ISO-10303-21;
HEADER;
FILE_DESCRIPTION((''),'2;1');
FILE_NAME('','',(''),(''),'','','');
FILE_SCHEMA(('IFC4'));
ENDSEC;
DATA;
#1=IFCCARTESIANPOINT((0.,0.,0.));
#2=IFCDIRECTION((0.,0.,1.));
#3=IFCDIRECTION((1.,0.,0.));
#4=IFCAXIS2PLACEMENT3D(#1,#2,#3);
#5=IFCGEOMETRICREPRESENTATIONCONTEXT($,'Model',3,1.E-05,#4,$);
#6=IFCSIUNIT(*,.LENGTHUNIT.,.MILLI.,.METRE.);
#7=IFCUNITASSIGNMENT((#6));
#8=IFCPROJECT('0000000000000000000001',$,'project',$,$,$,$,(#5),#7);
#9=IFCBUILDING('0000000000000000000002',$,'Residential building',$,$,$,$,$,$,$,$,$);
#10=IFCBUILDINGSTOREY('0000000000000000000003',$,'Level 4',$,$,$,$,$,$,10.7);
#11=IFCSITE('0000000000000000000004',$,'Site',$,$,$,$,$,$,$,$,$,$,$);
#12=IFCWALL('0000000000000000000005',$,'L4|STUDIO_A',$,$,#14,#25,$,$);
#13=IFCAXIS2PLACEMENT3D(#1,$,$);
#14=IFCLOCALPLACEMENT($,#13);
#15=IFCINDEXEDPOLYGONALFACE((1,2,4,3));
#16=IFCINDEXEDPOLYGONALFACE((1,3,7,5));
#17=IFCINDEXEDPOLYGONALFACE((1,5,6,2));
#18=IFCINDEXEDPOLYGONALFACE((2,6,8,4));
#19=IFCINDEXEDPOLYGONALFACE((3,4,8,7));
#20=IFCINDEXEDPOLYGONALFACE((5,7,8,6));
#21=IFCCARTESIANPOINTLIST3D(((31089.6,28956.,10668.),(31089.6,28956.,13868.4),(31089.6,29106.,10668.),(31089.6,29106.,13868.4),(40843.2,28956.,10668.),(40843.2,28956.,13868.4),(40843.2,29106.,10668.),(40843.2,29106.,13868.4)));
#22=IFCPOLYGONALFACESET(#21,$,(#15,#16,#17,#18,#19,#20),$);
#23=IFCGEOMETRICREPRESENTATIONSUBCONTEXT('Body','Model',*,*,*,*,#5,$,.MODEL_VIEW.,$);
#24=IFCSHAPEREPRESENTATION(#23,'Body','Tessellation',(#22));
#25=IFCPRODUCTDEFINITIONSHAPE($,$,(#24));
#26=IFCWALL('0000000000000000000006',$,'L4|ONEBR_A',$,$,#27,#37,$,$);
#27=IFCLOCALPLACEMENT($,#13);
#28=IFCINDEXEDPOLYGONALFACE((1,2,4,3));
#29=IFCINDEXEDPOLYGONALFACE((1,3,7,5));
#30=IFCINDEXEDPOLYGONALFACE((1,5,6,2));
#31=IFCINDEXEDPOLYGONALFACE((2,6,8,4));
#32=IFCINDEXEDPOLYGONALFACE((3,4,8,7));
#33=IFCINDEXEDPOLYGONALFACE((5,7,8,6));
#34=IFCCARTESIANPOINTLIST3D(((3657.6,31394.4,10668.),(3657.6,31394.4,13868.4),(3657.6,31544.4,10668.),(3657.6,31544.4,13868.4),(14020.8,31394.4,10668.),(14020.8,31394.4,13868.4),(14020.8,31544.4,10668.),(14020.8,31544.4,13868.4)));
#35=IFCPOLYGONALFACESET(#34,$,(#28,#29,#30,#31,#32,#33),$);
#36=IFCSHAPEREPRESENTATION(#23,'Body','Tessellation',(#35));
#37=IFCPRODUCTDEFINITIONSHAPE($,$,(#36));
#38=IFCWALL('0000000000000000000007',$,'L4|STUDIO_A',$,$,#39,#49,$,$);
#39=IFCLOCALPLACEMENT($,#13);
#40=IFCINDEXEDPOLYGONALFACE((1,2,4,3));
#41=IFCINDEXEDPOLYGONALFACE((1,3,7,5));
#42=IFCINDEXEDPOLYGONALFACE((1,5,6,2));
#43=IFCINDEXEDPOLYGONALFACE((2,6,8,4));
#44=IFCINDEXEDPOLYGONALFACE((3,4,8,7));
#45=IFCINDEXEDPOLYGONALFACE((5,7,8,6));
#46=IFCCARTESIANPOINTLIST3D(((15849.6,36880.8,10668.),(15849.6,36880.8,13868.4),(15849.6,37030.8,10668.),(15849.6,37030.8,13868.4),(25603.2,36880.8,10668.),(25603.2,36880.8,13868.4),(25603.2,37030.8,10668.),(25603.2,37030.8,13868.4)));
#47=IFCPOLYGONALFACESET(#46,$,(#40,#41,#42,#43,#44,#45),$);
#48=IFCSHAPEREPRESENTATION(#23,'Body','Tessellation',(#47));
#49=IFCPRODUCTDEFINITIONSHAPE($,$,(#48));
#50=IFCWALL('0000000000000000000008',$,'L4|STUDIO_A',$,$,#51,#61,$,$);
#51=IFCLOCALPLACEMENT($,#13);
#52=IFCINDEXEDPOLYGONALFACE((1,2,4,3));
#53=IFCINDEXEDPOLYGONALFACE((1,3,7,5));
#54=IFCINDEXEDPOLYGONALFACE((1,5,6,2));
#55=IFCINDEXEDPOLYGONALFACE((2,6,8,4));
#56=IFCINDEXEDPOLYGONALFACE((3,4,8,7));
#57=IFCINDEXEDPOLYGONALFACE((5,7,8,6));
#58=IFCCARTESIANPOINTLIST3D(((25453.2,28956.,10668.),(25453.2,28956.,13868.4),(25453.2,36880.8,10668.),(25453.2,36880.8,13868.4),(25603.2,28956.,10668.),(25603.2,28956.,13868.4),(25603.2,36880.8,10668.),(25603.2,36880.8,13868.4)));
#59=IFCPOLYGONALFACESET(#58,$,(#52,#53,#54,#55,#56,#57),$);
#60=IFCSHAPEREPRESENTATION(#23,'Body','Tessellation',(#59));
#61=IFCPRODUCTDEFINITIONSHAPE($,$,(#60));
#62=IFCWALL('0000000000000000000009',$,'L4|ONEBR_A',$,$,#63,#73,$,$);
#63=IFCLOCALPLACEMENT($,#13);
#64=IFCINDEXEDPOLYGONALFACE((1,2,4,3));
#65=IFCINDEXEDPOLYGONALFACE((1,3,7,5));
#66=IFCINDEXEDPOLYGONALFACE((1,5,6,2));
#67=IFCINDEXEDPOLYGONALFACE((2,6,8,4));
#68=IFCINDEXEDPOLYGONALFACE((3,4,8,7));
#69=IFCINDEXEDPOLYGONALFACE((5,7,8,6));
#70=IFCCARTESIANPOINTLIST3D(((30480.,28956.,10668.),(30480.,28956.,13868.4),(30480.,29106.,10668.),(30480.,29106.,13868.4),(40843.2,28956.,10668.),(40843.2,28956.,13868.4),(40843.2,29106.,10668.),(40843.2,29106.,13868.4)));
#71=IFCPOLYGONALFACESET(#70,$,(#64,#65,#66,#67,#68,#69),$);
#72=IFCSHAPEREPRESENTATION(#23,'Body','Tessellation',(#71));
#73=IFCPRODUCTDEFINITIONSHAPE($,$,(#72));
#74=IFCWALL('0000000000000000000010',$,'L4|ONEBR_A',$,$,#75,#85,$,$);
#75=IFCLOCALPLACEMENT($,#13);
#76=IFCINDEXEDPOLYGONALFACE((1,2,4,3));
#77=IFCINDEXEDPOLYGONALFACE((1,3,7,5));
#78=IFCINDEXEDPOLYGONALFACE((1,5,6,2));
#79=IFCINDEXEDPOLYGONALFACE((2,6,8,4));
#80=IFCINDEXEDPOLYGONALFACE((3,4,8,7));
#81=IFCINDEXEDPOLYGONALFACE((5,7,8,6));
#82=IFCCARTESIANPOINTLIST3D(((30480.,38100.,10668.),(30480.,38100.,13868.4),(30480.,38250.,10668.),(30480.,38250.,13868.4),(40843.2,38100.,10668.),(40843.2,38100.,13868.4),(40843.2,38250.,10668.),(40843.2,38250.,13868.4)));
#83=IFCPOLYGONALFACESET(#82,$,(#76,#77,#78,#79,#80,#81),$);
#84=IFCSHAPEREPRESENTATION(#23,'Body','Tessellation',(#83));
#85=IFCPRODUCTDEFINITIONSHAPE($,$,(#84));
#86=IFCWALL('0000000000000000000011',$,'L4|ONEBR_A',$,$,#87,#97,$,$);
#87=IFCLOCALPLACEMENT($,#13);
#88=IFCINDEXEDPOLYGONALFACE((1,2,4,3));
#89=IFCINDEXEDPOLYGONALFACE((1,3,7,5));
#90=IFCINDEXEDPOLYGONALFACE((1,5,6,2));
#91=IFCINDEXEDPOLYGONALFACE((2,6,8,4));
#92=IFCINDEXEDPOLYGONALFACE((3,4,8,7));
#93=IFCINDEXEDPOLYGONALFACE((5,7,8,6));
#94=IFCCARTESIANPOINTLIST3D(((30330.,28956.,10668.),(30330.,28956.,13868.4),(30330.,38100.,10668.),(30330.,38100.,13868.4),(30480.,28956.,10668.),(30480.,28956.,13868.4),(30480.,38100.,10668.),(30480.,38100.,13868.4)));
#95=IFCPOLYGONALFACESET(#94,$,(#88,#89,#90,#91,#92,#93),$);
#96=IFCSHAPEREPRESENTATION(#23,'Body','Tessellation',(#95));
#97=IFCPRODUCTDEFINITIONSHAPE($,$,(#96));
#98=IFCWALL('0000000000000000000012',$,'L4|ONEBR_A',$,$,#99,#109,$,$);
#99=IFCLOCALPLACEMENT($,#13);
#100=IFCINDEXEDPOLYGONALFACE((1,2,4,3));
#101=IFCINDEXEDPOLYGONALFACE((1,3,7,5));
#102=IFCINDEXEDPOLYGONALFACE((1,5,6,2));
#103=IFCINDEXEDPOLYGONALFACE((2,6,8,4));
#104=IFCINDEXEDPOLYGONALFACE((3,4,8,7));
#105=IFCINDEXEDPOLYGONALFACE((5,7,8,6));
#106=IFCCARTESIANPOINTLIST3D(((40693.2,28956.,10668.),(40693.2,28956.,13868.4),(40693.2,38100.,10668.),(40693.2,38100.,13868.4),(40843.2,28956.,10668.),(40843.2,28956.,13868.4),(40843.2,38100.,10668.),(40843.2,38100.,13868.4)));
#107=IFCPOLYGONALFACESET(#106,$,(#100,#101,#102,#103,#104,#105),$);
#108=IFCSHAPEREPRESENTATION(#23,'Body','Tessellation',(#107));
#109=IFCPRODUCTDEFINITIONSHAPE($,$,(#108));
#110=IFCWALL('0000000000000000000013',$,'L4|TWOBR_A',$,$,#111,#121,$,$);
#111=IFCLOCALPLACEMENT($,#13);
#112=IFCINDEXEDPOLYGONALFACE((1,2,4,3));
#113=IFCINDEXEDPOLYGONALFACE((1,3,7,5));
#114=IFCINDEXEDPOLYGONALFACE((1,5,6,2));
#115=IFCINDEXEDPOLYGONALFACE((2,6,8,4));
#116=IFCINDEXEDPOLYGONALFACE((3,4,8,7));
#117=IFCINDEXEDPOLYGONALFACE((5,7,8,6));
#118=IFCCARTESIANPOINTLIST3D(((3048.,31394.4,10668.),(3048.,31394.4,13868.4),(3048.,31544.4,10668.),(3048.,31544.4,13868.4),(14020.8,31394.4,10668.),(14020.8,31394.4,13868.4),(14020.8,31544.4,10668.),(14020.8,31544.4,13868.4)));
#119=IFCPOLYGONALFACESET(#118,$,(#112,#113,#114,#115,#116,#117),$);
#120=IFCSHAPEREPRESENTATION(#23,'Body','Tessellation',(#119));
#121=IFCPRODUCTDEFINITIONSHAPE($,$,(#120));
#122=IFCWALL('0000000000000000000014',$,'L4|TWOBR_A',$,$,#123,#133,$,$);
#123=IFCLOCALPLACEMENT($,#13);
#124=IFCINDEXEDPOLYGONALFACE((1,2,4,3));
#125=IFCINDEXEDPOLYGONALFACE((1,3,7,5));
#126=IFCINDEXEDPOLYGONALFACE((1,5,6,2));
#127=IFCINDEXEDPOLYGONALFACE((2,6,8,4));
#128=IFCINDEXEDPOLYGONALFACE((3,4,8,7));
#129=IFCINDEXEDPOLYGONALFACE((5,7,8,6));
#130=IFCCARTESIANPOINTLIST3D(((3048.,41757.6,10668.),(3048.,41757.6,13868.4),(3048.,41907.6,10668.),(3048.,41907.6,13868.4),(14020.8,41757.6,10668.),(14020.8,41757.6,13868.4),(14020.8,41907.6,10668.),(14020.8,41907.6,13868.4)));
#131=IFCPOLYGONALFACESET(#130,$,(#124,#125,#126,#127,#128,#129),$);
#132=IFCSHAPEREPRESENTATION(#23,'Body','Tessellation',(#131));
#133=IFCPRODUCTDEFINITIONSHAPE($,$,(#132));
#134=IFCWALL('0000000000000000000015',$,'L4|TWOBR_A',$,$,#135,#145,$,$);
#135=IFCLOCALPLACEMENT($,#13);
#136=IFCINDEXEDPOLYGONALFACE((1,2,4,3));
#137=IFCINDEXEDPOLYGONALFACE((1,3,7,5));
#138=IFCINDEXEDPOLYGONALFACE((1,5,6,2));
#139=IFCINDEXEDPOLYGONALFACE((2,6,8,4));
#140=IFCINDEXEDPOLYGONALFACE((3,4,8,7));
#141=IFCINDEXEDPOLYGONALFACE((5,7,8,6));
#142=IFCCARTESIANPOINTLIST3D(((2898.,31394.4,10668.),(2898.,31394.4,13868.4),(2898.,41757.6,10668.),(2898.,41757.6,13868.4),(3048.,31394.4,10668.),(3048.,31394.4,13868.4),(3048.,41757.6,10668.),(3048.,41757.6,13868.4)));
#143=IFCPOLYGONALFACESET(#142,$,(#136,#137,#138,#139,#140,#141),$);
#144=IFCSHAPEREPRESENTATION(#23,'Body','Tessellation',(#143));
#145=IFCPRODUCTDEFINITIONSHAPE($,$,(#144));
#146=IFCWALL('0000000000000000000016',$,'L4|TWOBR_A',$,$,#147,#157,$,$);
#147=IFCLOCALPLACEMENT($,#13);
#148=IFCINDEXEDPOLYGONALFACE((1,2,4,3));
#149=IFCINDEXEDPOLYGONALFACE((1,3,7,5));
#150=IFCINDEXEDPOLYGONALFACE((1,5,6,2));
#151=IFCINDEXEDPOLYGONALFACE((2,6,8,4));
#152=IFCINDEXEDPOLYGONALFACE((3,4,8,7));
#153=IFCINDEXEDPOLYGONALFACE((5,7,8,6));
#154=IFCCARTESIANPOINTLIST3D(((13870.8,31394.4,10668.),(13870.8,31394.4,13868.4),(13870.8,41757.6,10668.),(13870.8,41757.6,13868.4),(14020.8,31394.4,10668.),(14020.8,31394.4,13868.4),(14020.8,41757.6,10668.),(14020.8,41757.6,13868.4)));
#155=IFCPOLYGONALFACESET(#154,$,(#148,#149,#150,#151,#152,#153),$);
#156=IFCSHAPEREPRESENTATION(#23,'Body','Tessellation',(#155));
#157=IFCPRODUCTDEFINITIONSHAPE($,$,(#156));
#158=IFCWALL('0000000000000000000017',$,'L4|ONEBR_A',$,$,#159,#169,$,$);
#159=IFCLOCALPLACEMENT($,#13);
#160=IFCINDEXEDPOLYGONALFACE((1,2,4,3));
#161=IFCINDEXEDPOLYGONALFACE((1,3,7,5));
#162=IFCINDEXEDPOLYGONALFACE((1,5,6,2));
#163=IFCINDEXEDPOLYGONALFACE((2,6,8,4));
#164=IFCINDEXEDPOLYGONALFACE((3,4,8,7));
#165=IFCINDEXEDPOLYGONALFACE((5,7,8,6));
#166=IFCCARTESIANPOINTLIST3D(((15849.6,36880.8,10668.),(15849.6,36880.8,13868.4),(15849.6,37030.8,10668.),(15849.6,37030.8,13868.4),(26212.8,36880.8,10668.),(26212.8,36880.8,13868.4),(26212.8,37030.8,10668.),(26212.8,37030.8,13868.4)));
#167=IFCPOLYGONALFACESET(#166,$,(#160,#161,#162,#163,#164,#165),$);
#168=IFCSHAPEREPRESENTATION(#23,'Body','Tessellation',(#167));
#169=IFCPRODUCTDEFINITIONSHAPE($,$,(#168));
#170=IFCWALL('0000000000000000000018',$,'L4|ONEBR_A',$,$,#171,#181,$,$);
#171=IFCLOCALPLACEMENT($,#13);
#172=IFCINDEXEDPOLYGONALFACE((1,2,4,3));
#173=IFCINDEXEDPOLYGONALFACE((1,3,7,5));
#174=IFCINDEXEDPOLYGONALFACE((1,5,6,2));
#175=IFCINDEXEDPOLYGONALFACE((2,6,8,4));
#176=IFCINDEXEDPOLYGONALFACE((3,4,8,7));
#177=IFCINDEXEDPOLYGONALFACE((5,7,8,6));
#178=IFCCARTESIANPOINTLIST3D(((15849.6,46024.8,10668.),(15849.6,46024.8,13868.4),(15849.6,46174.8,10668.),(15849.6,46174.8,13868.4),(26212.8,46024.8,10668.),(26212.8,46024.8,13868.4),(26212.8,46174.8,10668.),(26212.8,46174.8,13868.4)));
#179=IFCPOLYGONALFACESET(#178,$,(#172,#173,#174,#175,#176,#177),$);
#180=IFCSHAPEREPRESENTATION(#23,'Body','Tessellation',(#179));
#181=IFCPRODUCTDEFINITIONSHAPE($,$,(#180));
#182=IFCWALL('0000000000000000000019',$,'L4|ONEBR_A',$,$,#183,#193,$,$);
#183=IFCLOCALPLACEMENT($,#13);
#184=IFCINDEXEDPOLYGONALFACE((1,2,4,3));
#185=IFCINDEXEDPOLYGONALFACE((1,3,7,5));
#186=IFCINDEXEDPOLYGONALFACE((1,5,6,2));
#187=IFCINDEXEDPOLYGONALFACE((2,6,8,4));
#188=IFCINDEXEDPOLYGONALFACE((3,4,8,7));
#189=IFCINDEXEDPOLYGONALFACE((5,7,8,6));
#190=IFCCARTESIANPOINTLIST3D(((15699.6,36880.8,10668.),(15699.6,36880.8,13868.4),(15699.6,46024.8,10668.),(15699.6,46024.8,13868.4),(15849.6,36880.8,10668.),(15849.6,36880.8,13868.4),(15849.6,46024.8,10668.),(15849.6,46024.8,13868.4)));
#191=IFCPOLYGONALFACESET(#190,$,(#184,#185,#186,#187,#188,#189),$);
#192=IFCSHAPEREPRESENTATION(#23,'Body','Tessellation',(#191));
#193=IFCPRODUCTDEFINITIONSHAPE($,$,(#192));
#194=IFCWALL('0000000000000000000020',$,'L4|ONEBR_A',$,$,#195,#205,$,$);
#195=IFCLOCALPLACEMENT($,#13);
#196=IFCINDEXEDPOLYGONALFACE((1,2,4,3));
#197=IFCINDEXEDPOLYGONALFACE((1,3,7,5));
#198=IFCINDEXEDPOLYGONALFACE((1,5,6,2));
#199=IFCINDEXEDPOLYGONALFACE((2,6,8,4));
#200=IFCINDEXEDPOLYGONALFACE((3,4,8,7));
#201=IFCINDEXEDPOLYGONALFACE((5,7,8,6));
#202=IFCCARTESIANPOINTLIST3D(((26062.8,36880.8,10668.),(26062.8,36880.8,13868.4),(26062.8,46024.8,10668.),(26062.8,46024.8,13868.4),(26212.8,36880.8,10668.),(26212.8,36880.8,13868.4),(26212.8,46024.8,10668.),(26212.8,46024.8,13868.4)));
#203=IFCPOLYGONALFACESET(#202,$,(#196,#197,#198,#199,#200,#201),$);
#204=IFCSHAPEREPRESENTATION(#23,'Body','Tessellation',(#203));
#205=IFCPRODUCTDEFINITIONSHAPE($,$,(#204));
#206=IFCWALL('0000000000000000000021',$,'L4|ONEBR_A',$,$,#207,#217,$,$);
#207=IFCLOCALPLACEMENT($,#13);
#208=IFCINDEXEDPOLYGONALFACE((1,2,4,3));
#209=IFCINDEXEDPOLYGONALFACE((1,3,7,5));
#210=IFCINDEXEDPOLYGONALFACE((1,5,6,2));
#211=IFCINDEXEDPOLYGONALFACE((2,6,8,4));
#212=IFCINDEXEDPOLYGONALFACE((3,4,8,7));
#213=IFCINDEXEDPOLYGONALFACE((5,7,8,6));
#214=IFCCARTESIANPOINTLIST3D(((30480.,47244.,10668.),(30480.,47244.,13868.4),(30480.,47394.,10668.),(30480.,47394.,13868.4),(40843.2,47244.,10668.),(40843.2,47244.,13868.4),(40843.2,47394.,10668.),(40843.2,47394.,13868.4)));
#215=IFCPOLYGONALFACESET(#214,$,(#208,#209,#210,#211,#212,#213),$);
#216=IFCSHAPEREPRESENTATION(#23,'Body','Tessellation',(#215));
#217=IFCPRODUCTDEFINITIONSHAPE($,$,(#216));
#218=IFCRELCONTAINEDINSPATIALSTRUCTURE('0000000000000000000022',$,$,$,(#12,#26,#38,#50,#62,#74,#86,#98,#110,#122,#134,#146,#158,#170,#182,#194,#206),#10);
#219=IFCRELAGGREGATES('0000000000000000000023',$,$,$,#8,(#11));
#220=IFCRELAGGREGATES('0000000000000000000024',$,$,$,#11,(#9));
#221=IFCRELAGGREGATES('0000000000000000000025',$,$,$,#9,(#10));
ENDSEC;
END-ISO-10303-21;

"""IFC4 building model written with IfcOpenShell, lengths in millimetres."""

from ifc_helpers import new_model, si_unit, frame, origin_with_axes, place, context, subcontext, project, spatial, indexed_curve, outline, extrude, element, save


model = new_model("IFC4")

# Units and contexts
model_context = context("Model", 3, precision=1e-05, world=origin_with_axes())
body_context = subcontext(model_context, "Body", "Model", "MODEL_VIEW")
ifc_project = project(units=[si_unit("LENGTHUNIT", "METRE", prefix="MILLI")], contexts=[model_context])

# Site, building, storey
site = spatial("IfcSite", under=ifc_project, Name="Site")
building = spatial("IfcBuilding", under=site, Name="Residential building")
storey = spatial("IfcBuildingStorey", under=building, Name="Level 4", Elevation=10.7)

# Walls
wall_1_placement = place(None, frame((31089.6, 28956.0, 10668.0), z_axis=(0.0, 0.0, 1.0), x_axis=(1.0, 0.0, 0.0)))
element("IfcWall", 1, at=wall_1_placement, inside=storey, Name="L4|STUDIO_A", context=body_context, shape_type="SweptSolid", body=[
    extrude(outline(indexed_curve([(0.0, 0.0), (0.0, 150.0), (9753.6, 150.0), (9753.6, 0.0), (0.0, 0.0)], self_intersect=False)), origin_with_axes(), (0.0, 0.0, 1.0), 3200.4),
])
wall_2_placement = place(None, frame((3657.6, 31394.4, 10668.0), z_axis=(0.0, 0.0, 1.0), x_axis=(1.0, 0.0, 0.0)))
element("IfcWall", 2, at=wall_2_placement, inside=storey, Name="L4|ONEBR_A", context=body_context, shape_type="SweptSolid", body=[
    extrude(outline(indexed_curve([(0.0, 0.0), (0.0, 150.0), (10363.2, 150.0), (10363.2, 0.0), (0.0, 0.0)], self_intersect=False)), origin_with_axes(), (0.0, 0.0, 1.0), 3200.4),
])
wall_3_placement = place(None, frame((15849.6, 36880.8, 10668.0), z_axis=(0.0, 0.0, 1.0), x_axis=(1.0, 0.0, 0.0)))
element("IfcWall", 3, at=wall_3_placement, inside=storey, Name="L4|STUDIO_A", context=body_context, shape_type="SweptSolid", body=[
    extrude(outline(indexed_curve([(0.0, 0.0), (0.0, 150.0), (9753.6, 150.0), (9753.6, 0.0), (0.0, 0.0)], self_intersect=False)), origin_with_axes(), (0.0, 0.0, 1.0), 3200.4),
])
wall_4_placement = place(None, frame((25603.2, 28956.0, 10668.0), z_axis=(0.0, 0.0, 1.0), x_axis=(0.0, 1.0, 0.0)))
element("IfcWall", 4, at=wall_4_placement, inside=storey, Name="L4|STUDIO_A", context=body_context, shape_type="SweptSolid", body=[
    extrude(outline(indexed_curve([(0.0, 0.0), (0.0, 150.0), (7924.8, 150.0), (7924.8, 0.0), (0.0, 0.0)], self_intersect=False)), origin_with_axes(), (0.0, 0.0, 1.0), 3200.4),
])
for number, where, z_axis, x_axis, name in (
    (5, (30480.0, 28956.0, 10668.0), (0.0, 0.0, 1.0), (1.0, 0.0, 0.0), "L4|ONEBR_A"),
    (6, (30480.0, 38100.0, 10668.0), (0.0, 0.0, 1.0), (1.0, 0.0, 0.0), "L4|ONEBR_A"),
):
    element("IfcWall", number, at=place(None, frame(where, z_axis=z_axis, x_axis=x_axis)), inside=storey, Name=name, context=body_context, shape_type="SweptSolid", body=[
        extrude(outline(indexed_curve([(0.0, 0.0), (0.0, 150.0), (10363.2, 150.0), (10363.2, 0.0), (0.0, 0.0)], self_intersect=False)), origin_with_axes(), (0.0, 0.0, 1.0), 3200.4),
    ])
for number, where, z_axis, x_axis, name in (
    (7, (30480.0, 28956.0, 10668.0), (0.0, 0.0, 1.0), (0.0, 1.0, 0.0), "L4|ONEBR_A"),
    (8, (40843.2, 28956.0, 10668.0), (0.0, 0.0, 1.0), (0.0, 1.0, 0.0), "L4|ONEBR_A"),
):
    element("IfcWall", number, at=place(None, frame(where, z_axis=z_axis, x_axis=x_axis)), inside=storey, Name=name, context=body_context, shape_type="SweptSolid", body=[
        extrude(outline(indexed_curve([(0.0, 0.0), (0.0, 150.0), (9144.0, 150.0), (9144.0, 0.0), (0.0, 0.0)], self_intersect=False)), origin_with_axes(), (0.0, 0.0, 1.0), 3200.4),
    ])
for number, where, z_axis, x_axis, name in (
    (9, (3048.0, 31394.4, 10668.0), (0.0, 0.0, 1.0), (1.0, 0.0, 0.0), "L4|TWOBR_A"),
    (10, (3048.0, 41757.6, 10668.0), (0.0, 0.0, 1.0), (1.0, 0.0, 0.0), "L4|TWOBR_A"),
):
    element("IfcWall", number, at=place(None, frame(where, z_axis=z_axis, x_axis=x_axis)), inside=storey, Name=name, context=body_context, shape_type="SweptSolid", body=[
        extrude(outline(indexed_curve([(0.0, 0.0), (0.0, 150.0), (10972.8, 150.0), (10972.8, 0.0), (0.0, 0.0)], self_intersect=False)), origin_with_axes(), (0.0, 0.0, 1.0), 3200.4),
    ])
for number, where, z_axis, x_axis, name in (
    (11, (3048.0, 31394.4, 10668.0), (0.0, 0.0, 1.0), (0.0, 1.0, 0.0), "L4|TWOBR_A"),
    (12, (14020.8, 31394.4, 10668.0), (0.0, 0.0, 1.0), (0.0, 1.0, 0.0), "L4|TWOBR_A"),
    (13, (15849.6, 36880.8, 10668.0), (0.0, 0.0, 1.0), (1.0, 0.0, 0.0), "L4|ONEBR_A"),
    (14, (15849.6, 46024.8, 10668.0), (0.0, 0.0, 1.0), (1.0, 0.0, 0.0), "L4|ONEBR_A"),
):
    element("IfcWall", number, at=place(None, frame(where, z_axis=z_axis, x_axis=x_axis)), inside=storey, Name=name, context=body_context, shape_type="SweptSolid", body=[
        extrude(outline(indexed_curve([(0.0, 0.0), (0.0, 150.0), (10363.2, 150.0), (10363.2, 0.0), (0.0, 0.0)], self_intersect=False)), origin_with_axes(), (0.0, 0.0, 1.0), 3200.4),
    ])
for number, where, z_axis, x_axis, name in (
    (15, (15849.6, 36880.8, 10668.0), (0.0, 0.0, 1.0), (0.0, 1.0, 0.0), "L4|ONEBR_A"),
    (16, (26212.8, 36880.8, 10668.0), (0.0, 0.0, 1.0), (0.0, 1.0, 0.0), "L4|ONEBR_A"),
):
    element("IfcWall", number, at=place(None, frame(where, z_axis=z_axis, x_axis=x_axis)), inside=storey, Name=name, context=body_context, shape_type="SweptSolid", body=[
        extrude(outline(indexed_curve([(0.0, 0.0), (0.0, 150.0), (9144.0, 150.0), (9144.0, 0.0), (0.0, 0.0)], self_intersect=False)), origin_with_axes(), (0.0, 0.0, 1.0), 3200.4),
    ])
for number, where, z_axis, x_axis, name in (
    (17, (30480.0, 47244.0, 10668.0), (0.0, 0.0, 1.0), (1.0, 0.0, 0.0), "L4|ONEBR_A"),
):
    element("IfcWall", number, at=place(None, frame(where, z_axis=z_axis, x_axis=x_axis)), inside=storey, Name=name, context=body_context, shape_type="SweptSolid", body=[
        extrude(outline(indexed_curve([(0.0, 0.0), (0.0, 150.0), (10363.2, 150.0), (10363.2, 0.0), (0.0, 0.0)], self_intersect=False)), origin_with_axes(), (0.0, 0.0, 1.0), 3200.4),
    ])

save(model, "model.ifc")
